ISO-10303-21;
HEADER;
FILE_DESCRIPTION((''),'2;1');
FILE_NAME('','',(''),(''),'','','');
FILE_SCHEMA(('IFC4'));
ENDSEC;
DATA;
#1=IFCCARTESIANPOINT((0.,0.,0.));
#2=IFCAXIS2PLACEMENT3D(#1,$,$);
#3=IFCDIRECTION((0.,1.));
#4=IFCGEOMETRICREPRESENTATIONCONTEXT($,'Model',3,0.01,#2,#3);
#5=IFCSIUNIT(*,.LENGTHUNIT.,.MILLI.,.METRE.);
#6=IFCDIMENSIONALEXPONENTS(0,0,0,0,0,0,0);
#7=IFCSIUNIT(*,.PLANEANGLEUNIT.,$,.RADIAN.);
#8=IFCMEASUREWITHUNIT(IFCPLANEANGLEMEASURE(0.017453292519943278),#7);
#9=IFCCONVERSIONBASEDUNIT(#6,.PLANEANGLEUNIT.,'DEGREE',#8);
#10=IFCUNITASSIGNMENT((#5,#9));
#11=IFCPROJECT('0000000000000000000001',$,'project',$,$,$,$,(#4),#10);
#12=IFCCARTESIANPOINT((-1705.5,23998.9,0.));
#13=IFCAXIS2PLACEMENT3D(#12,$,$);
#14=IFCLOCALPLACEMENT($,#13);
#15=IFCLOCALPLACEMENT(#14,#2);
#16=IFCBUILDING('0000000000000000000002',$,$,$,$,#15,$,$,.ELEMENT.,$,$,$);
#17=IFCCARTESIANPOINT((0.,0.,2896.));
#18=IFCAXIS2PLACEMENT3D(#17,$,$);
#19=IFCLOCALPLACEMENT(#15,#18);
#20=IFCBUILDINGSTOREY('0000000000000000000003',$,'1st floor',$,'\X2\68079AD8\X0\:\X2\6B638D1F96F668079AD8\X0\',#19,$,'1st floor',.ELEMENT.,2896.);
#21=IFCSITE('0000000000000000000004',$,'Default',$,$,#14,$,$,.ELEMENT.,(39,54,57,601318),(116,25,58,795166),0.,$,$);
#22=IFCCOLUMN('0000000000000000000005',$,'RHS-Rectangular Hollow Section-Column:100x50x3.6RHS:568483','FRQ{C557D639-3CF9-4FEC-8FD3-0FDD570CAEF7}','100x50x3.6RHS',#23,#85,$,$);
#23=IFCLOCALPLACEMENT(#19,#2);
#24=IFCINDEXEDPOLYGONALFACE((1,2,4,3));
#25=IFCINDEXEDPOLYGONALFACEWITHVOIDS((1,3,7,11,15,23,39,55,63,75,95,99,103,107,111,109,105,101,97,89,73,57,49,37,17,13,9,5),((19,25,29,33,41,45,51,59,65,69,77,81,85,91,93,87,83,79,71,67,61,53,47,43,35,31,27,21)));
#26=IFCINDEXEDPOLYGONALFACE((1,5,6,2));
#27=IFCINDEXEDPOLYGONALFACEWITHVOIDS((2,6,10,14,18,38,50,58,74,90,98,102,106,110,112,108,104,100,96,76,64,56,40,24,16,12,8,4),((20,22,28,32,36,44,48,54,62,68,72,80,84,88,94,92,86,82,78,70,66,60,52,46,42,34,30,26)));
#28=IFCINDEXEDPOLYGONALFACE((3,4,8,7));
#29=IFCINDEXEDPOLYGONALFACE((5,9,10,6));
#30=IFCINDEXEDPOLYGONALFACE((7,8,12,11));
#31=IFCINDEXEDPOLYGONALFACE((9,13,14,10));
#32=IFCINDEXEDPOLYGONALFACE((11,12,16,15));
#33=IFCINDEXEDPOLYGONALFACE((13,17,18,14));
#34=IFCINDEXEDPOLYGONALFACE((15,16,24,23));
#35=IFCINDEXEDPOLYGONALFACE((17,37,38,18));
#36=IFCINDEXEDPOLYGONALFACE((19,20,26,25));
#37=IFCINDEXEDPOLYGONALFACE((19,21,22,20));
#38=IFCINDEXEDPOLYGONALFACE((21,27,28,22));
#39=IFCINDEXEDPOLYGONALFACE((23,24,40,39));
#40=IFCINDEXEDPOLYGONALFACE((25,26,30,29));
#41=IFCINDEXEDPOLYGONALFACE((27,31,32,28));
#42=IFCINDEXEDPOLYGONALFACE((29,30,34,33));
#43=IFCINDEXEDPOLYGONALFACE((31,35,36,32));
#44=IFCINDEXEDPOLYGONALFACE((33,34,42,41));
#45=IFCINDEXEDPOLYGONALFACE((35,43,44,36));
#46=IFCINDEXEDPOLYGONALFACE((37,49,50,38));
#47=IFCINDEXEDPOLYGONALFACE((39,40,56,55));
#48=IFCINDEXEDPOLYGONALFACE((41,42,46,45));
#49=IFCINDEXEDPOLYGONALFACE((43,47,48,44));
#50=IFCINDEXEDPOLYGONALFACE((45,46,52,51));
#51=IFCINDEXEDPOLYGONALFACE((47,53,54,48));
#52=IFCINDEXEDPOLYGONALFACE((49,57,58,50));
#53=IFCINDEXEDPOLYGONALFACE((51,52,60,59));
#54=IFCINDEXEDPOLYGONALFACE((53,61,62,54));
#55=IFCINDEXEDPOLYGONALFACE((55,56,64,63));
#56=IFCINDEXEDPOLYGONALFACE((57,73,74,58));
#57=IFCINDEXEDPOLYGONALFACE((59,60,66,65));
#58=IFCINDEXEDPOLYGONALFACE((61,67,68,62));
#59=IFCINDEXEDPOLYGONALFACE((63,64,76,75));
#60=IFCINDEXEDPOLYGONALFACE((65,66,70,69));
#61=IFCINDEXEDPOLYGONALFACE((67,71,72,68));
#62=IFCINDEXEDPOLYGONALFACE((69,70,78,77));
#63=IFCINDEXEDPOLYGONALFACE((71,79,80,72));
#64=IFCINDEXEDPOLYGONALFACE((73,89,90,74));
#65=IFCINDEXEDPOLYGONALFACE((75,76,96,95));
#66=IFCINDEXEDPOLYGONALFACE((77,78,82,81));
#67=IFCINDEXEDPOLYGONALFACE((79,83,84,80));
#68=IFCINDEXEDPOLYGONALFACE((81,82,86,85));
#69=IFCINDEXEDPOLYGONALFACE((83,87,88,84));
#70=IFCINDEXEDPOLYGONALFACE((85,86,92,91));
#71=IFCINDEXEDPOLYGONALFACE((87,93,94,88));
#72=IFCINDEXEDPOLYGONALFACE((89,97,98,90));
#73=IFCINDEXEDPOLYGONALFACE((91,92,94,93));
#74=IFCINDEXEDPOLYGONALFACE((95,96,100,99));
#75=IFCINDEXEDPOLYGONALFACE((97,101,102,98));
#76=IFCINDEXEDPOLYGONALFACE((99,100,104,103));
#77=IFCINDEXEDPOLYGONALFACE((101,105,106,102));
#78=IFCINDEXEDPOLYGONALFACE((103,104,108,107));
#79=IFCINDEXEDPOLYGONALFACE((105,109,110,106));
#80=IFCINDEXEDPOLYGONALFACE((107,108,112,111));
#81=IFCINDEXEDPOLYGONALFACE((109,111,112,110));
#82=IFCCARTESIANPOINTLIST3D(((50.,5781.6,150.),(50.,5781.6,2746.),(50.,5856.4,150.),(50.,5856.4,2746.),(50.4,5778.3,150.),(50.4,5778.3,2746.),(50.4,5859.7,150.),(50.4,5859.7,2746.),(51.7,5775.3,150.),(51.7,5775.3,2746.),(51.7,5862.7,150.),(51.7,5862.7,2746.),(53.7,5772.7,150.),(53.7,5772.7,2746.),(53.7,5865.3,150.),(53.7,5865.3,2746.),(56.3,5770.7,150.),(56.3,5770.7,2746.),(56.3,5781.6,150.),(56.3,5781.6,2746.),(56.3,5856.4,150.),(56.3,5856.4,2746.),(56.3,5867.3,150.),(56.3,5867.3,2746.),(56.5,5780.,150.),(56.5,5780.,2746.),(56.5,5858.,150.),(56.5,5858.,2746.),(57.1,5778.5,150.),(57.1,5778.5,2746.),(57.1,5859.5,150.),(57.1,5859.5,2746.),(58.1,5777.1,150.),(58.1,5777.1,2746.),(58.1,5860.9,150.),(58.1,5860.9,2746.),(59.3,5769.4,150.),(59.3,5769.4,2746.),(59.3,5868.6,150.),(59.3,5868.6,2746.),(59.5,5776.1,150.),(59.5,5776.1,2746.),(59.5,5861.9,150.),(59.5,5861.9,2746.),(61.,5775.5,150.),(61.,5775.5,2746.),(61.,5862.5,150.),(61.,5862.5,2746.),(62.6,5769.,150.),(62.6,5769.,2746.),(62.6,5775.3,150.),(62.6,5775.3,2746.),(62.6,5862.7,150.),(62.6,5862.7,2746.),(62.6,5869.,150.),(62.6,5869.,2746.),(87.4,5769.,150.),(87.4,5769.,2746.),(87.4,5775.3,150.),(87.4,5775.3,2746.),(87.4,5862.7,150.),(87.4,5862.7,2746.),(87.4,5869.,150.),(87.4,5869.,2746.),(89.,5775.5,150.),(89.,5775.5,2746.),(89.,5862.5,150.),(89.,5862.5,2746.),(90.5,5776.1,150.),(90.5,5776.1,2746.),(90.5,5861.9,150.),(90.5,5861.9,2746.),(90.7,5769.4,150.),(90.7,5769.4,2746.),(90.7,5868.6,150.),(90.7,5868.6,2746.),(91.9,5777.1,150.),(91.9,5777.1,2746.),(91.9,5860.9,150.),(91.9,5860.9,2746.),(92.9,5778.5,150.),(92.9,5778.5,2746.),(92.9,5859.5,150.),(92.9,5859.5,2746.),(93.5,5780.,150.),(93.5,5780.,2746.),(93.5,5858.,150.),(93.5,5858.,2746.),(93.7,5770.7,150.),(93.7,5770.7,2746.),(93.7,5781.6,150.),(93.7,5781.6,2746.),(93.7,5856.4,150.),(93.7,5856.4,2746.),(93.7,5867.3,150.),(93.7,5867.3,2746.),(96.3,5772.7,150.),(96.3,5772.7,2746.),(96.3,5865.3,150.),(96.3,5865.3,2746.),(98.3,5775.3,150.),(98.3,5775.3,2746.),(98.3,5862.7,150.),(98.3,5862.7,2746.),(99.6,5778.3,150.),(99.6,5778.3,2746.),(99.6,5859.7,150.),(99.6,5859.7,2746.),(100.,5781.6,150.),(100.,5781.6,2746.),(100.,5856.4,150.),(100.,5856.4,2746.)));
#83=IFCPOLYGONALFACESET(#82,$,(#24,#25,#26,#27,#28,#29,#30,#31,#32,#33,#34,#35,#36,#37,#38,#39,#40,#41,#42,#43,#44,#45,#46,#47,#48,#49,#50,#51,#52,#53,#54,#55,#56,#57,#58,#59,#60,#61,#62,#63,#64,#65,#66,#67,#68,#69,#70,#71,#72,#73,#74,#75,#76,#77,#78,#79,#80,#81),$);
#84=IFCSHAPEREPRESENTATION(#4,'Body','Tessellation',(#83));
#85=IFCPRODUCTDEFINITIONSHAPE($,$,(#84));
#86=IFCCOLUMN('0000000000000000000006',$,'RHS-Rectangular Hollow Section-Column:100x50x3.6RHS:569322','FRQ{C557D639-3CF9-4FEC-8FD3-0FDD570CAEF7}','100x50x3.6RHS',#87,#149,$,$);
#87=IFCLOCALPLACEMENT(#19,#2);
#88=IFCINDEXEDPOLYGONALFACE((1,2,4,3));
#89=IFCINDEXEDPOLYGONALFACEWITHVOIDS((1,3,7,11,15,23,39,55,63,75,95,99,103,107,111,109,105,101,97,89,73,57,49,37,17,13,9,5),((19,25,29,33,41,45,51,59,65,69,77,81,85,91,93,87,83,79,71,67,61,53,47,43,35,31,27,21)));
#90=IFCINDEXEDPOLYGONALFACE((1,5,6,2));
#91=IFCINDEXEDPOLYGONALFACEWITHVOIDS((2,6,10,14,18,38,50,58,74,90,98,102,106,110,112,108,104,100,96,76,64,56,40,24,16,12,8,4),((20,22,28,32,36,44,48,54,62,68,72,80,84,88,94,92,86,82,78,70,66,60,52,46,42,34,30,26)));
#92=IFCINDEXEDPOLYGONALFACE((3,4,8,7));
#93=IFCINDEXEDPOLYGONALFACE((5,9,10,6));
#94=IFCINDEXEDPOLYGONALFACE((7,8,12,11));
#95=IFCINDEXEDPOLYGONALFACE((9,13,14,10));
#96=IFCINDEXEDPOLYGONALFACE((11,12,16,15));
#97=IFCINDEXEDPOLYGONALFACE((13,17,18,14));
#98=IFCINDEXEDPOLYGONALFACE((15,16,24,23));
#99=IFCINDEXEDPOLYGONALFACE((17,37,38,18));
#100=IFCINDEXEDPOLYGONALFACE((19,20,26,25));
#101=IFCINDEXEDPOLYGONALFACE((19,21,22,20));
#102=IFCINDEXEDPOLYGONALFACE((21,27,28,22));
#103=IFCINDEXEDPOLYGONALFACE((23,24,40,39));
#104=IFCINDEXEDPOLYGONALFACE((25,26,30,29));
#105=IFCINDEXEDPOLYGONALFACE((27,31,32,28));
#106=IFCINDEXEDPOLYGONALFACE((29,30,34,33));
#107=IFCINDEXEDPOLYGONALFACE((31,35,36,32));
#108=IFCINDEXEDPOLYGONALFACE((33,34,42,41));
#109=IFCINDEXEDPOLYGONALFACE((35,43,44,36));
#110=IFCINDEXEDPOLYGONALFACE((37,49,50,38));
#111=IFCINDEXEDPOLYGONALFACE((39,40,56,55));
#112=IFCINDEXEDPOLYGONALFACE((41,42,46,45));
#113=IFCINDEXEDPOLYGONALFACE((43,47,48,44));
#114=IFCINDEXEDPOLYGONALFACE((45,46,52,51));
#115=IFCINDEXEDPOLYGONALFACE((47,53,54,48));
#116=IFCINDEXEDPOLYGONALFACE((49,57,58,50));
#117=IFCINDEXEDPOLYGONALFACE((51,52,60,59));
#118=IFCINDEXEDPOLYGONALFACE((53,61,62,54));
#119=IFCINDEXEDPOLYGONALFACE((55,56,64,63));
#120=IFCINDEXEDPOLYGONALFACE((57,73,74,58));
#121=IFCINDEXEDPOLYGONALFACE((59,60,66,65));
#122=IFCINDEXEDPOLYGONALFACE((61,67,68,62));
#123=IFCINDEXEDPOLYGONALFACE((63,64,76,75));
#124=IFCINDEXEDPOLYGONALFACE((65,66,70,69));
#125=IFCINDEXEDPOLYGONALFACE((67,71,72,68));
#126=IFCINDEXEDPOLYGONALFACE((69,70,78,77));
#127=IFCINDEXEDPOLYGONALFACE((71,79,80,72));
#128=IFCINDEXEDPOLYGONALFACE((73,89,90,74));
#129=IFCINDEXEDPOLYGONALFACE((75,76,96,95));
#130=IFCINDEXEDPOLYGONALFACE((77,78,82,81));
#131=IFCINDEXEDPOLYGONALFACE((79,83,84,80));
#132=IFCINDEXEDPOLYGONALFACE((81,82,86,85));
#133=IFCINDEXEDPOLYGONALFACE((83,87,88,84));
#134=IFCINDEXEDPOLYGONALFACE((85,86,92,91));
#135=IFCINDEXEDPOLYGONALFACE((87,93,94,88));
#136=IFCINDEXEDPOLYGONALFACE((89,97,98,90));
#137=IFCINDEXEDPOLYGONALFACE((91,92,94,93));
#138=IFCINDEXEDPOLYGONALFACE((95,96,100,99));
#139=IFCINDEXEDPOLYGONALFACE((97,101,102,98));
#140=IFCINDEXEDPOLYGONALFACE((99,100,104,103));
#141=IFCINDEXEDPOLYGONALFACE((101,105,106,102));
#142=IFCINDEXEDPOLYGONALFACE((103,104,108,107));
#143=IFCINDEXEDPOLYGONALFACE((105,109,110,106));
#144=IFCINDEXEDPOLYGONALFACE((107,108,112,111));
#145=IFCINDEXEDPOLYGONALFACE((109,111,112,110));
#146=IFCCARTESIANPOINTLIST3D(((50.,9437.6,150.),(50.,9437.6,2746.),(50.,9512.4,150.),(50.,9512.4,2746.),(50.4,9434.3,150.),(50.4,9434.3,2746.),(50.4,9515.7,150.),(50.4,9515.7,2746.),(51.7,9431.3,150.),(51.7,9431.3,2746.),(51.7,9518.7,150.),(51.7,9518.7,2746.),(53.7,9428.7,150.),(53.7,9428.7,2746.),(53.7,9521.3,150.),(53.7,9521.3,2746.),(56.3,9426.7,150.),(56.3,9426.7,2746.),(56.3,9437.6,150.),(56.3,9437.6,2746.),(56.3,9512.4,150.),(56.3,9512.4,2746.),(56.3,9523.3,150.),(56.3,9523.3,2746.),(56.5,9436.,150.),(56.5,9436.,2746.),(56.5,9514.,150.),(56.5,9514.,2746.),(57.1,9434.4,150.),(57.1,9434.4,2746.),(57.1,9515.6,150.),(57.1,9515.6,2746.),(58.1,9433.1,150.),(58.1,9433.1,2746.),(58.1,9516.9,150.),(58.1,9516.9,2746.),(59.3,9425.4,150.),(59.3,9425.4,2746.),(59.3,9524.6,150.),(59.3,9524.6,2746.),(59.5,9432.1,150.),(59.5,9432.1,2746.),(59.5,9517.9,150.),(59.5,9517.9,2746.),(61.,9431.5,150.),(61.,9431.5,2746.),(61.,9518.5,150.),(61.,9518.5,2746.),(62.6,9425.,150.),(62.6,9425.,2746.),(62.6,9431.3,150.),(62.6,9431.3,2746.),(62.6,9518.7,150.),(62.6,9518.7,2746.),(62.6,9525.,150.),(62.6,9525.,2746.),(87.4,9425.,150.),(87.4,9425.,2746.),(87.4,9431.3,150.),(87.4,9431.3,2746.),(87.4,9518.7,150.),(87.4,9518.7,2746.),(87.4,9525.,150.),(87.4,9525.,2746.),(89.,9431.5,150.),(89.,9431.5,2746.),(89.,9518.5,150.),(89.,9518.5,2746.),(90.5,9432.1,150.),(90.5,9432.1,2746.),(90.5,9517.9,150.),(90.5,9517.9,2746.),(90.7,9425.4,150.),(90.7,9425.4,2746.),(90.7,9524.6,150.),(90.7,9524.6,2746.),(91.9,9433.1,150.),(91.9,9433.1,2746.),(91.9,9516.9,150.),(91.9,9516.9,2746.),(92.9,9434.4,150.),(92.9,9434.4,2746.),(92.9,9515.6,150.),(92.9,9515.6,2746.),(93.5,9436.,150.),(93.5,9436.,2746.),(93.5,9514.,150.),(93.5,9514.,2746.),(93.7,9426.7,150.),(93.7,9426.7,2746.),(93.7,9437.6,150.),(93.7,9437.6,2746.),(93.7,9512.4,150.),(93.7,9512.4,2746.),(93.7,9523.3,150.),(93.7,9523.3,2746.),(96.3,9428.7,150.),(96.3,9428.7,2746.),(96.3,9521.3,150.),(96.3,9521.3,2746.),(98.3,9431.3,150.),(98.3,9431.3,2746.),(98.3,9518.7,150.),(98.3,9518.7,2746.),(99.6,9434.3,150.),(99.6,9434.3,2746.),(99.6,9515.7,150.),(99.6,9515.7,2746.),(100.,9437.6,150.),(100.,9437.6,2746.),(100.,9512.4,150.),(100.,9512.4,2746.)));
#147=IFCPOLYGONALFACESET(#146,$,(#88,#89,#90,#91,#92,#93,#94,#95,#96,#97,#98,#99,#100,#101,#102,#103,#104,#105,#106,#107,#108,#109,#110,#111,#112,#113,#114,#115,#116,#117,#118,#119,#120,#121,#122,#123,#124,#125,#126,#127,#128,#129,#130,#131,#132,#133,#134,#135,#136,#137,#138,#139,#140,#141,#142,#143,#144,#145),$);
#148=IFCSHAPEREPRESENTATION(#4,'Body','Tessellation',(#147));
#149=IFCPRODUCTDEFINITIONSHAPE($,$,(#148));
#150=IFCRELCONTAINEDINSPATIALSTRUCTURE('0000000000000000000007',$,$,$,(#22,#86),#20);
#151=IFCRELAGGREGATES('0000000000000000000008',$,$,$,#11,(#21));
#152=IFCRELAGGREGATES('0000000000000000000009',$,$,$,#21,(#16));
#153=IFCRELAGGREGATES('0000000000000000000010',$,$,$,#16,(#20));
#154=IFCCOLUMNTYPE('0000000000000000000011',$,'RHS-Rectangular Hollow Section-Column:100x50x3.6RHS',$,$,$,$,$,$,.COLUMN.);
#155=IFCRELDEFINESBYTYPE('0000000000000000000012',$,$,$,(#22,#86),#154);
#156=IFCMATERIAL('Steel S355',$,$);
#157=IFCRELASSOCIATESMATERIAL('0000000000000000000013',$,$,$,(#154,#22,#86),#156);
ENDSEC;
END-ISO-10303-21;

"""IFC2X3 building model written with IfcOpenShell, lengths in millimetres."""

from ifc_helpers import new_model, entity, si_unit, converted_unit, point, direction, frame, frame_2d, origin, origin_2d, place, context, project, spatial, circle_curve, line_curve, trimmed, segment, composite_curve, hollow_rectangle, outline, extrude, clip, halfspace, material, type_object, element, save


model = new_model("IFC2X3")

# Units and contexts
model_context = context("Model", 3, precision=0.01, world=origin(), true_north=direction((0.0, 1.0)))
ifc_project = project(units=[si_unit("LENGTHUNIT", "METRE", prefix="MILLI"), converted_unit("PLANEANGLEUNIT", "DEGREE", entity("IfcPlaneAngleMeasure", 0.017453292519943278), si_unit("PLANEANGLEUNIT", "RADIAN"), dimensions=[0, 0, 0, 0, 0, 0, 0])], contexts=[model_context])

# Site, building, storey
site_placement = place(None, frame((-1705.5, 23998.9, 0.0)))
site = spatial("IfcSite", under=ifc_project, at=site_placement, Name="Default", CompositionType="ELEMENT", RefLatitude=(39, 54, 57, 601318), RefLongitude=(116, 25, 58, 795166), RefElevation=0.0)
building_placement = place(site_placement, origin())
building = spatial("IfcBuilding", under=site, at=building_placement, CompositionType="ELEMENT")
storey_placement = place(building_placement, frame((0.0, 0.0, 2896.0)))
storey = spatial("IfcBuildingStorey", under=building, at=storey_placement, Name="1st floor", ObjectType="标高:正负零标高", LongName="1st floor", CompositionType="ELEMENT", Elevation=2896.0)

# Columns, openings
ifc_material_1 = material(Name="Steel S355")
column_type = type_object("IfcColumnType", Name="RHS-Rectangular Hollow Section-Column:100x50x3.6RHS", PredefinedType="COLUMN", material=ifc_material_1)
column_1_placement = place(storey_placement, frame((75.0, 5819.0, 2876.9)))
column_1 = element("IfcColumn", 1, at=column_1_placement, inside=storey, type_object=column_type, material=ifc_material_1, Name="RHS-Rectangular Hollow Section-Column:100x50x3.6RHS:568483", Description="FRQ{C557D639-3CF9-4FEC-8FD3-0FDD570CAEF7}", ObjectType="100x50x3.6RHS", context=model_context, shape_type="Clipping", body=[
    clip(clip(extrude(hollow_rectangle(XDim=50.0, YDim=100.0, WallThickness=6.3, InnerFilletRadius=6.3, OuterFilletRadius=12.6, at=origin_2d()), origin(), (0.0, 0.0, -1.0), 2782.8), halfspace(frame((-75.0, -5819.0, -2726.9), z_axis=(0.0, 0.0, 1.0), x_axis=(1.0, 0.0, 0.0)), True)), halfspace(frame((-75.0, -5819.0, -55.9), z_axis=(0.0, 0.0, -1.0), x_axis=(-1.0, 0.0, 0.0)), True)),
])
opening_1_placement = place(column_1_placement, frame((0.0, -150.1, -130.9), z_axis=(0.0, 1.0, 0.0), x_axis=(-1.0, 0.0, 0.0)))
element("IfcOpeningElement", 2, at=opening_1_placement, cuts=column_1, ObjectType="Opening", context=model_context, shape_type="SweptSolid", body=[
    extrude(outline(composite_curve([segment(trimmed(circle_curve(frame_2d((43.0, 32.0), x_axis=(1.0, 0.0)), 32.0), [point((43.0, 0.0))], [point((75.0, 32.0))], True, "CARTESIAN"), True, "CONTINUOUS"), segment(trimmed(line_curve((75.0, 32.0), (0.0, 1.0), 86.0), [point((75.0, 32.0))], [point((75.0, 118.0))], True, "CARTESIAN"), True, "CONTINUOUS"), segment(trimmed(circle_curve(frame_2d((43.0, 118.0), x_axis=(1.0, 0.0)), 32.0), [point((75.0, 118.0))], [point((43.0, 150.0))], True, "CARTESIAN"), True, "CONTINUOUS"), segment(trimmed(line_curve((43.0, 150.0), (-1.0, 0.0), 86.0), [point((43.0, 150.0))], [point((-43.0, 150.0))], True, "CARTESIAN"), True, "CONTINUOUS"), segment(trimmed(circle_curve(frame_2d((-43.0, 118.0), x_axis=(1.0, 0.0)), 32.0), [point((-43.0, 150.0))], [point((-75.0, 118.0))], True, "CARTESIAN"), True, "CONTINUOUS"), segment(trimmed(line_curve((-75.0, 118.0), (0.0, -1.0), 86.0), [point((-75.0, 118.0))], [point((-75.0, 32.0))], True, "CARTESIAN"), True, "CONTINUOUS"), segment(trimmed(circle_curve(frame_2d((-43.0, 32.0), x_axis=(1.0, 0.0)), 32.0), [point((-75.0, 32.0))], [point((-43.0, 0.0))], True, "CARTESIAN"), True, "CONTINUOUS"), segment(trimmed(line_curve((-43.0, 0.0), (1.0, 0.0), 86.0), [point((-43.0, 0.0))], [point((43.0, 0.0))], True, "CARTESIAN"), True, "CONTINUOUS")], self_intersect="UNKNOWN")), origin(), (0.0, 0.0, 1.0), 300.2),
])
column_2_placement = place(storey_placement, frame((75.0, 9475.0, 2876.9)))
column_2 = element("IfcColumn", 3, at=column_2_placement, inside=storey, type_object=column_type, material=ifc_material_1, Name="RHS-Rectangular Hollow Section-Column:100x50x3.6RHS:569322", Description="FRQ{C557D639-3CF9-4FEC-8FD3-0FDD570CAEF7}", ObjectType="100x50x3.6RHS", context=model_context, shape_type="Clipping", body=[
    clip(clip(extrude(hollow_rectangle(XDim=50.0, YDim=100.0, WallThickness=6.3, InnerFilletRadius=6.3, OuterFilletRadius=12.6, at=origin_2d()), origin(), (0.0, 0.0, -1.0), 2782.8), halfspace(frame((-75.0, -9475.0, -55.9), z_axis=(0.0, 0.0, -1.0), x_axis=(-1.0, 0.0, 0.0)), True)), halfspace(frame((-75.0, -9475.0, -2726.9), z_axis=(0.0, 0.0, 1.0), x_axis=(1.0, 0.0, 0.0)), True)),
])
opening_2_placement = place(column_2_placement, frame((0.0, -150.1, -130.9), z_axis=(0.0, 1.0, 0.0), x_axis=(-1.0, 0.0, 0.0)))
element("IfcOpeningElement", 4, at=opening_2_placement, cuts=column_2, ObjectType="Opening", context=model_context, shape_type="SweptSolid", body=[
    extrude(outline(composite_curve([segment(trimmed(circle_curve(frame_2d((43.0, 32.0), x_axis=(1.0, 0.0)), 32.0), [point((43.0, 0.0))], [point((75.0, 32.0))], True, "CARTESIAN"), True, "CONTINUOUS"), segment(trimmed(line_curve((75.0, 32.0), (0.0, 1.0), 86.0), [point((75.0, 32.0))], [point((75.0, 118.0))], True, "CARTESIAN"), True, "CONTINUOUS"), segment(trimmed(circle_curve(frame_2d((43.0, 118.0), x_axis=(1.0, 0.0)), 32.0), [point((75.0, 118.0))], [point((43.0, 150.0))], True, "CARTESIAN"), True, "CONTINUOUS"), segment(trimmed(line_curve((43.0, 150.0), (-1.0, 0.0), 86.0), [point((43.0, 150.0))], [point((-43.0, 150.0))], True, "CARTESIAN"), True, "CONTINUOUS"), segment(trimmed(circle_curve(frame_2d((-43.0, 118.0), x_axis=(1.0, 0.0)), 32.0), [point((-43.0, 150.0))], [point((-75.0, 118.0))], True, "CARTESIAN"), True, "CONTINUOUS"), segment(trimmed(line_curve((-75.0, 118.0), (0.0, -1.0), 86.0), [point((-75.0, 118.0))], [point((-75.0, 32.0))], True, "CARTESIAN"), True, "CONTINUOUS"), segment(trimmed(circle_curve(frame_2d((-43.0, 32.0), x_axis=(1.0, 0.0)), 32.0), [point((-75.0, 32.0))], [point((-43.0, 0.0))], True, "CARTESIAN"), True, "CONTINUOUS"), segment(trimmed(line_curve((-43.0, 0.0), (1.0, 0.0), 86.0), [point((-43.0, 0.0))], [point((43.0, 0.0))], True, "CARTESIAN"), True, "CONTINUOUS")], self_intersect="UNKNOWN")), origin(), (0.0, 0.0, 1.0), 300.2),
])

save(model, "model.ifc")
